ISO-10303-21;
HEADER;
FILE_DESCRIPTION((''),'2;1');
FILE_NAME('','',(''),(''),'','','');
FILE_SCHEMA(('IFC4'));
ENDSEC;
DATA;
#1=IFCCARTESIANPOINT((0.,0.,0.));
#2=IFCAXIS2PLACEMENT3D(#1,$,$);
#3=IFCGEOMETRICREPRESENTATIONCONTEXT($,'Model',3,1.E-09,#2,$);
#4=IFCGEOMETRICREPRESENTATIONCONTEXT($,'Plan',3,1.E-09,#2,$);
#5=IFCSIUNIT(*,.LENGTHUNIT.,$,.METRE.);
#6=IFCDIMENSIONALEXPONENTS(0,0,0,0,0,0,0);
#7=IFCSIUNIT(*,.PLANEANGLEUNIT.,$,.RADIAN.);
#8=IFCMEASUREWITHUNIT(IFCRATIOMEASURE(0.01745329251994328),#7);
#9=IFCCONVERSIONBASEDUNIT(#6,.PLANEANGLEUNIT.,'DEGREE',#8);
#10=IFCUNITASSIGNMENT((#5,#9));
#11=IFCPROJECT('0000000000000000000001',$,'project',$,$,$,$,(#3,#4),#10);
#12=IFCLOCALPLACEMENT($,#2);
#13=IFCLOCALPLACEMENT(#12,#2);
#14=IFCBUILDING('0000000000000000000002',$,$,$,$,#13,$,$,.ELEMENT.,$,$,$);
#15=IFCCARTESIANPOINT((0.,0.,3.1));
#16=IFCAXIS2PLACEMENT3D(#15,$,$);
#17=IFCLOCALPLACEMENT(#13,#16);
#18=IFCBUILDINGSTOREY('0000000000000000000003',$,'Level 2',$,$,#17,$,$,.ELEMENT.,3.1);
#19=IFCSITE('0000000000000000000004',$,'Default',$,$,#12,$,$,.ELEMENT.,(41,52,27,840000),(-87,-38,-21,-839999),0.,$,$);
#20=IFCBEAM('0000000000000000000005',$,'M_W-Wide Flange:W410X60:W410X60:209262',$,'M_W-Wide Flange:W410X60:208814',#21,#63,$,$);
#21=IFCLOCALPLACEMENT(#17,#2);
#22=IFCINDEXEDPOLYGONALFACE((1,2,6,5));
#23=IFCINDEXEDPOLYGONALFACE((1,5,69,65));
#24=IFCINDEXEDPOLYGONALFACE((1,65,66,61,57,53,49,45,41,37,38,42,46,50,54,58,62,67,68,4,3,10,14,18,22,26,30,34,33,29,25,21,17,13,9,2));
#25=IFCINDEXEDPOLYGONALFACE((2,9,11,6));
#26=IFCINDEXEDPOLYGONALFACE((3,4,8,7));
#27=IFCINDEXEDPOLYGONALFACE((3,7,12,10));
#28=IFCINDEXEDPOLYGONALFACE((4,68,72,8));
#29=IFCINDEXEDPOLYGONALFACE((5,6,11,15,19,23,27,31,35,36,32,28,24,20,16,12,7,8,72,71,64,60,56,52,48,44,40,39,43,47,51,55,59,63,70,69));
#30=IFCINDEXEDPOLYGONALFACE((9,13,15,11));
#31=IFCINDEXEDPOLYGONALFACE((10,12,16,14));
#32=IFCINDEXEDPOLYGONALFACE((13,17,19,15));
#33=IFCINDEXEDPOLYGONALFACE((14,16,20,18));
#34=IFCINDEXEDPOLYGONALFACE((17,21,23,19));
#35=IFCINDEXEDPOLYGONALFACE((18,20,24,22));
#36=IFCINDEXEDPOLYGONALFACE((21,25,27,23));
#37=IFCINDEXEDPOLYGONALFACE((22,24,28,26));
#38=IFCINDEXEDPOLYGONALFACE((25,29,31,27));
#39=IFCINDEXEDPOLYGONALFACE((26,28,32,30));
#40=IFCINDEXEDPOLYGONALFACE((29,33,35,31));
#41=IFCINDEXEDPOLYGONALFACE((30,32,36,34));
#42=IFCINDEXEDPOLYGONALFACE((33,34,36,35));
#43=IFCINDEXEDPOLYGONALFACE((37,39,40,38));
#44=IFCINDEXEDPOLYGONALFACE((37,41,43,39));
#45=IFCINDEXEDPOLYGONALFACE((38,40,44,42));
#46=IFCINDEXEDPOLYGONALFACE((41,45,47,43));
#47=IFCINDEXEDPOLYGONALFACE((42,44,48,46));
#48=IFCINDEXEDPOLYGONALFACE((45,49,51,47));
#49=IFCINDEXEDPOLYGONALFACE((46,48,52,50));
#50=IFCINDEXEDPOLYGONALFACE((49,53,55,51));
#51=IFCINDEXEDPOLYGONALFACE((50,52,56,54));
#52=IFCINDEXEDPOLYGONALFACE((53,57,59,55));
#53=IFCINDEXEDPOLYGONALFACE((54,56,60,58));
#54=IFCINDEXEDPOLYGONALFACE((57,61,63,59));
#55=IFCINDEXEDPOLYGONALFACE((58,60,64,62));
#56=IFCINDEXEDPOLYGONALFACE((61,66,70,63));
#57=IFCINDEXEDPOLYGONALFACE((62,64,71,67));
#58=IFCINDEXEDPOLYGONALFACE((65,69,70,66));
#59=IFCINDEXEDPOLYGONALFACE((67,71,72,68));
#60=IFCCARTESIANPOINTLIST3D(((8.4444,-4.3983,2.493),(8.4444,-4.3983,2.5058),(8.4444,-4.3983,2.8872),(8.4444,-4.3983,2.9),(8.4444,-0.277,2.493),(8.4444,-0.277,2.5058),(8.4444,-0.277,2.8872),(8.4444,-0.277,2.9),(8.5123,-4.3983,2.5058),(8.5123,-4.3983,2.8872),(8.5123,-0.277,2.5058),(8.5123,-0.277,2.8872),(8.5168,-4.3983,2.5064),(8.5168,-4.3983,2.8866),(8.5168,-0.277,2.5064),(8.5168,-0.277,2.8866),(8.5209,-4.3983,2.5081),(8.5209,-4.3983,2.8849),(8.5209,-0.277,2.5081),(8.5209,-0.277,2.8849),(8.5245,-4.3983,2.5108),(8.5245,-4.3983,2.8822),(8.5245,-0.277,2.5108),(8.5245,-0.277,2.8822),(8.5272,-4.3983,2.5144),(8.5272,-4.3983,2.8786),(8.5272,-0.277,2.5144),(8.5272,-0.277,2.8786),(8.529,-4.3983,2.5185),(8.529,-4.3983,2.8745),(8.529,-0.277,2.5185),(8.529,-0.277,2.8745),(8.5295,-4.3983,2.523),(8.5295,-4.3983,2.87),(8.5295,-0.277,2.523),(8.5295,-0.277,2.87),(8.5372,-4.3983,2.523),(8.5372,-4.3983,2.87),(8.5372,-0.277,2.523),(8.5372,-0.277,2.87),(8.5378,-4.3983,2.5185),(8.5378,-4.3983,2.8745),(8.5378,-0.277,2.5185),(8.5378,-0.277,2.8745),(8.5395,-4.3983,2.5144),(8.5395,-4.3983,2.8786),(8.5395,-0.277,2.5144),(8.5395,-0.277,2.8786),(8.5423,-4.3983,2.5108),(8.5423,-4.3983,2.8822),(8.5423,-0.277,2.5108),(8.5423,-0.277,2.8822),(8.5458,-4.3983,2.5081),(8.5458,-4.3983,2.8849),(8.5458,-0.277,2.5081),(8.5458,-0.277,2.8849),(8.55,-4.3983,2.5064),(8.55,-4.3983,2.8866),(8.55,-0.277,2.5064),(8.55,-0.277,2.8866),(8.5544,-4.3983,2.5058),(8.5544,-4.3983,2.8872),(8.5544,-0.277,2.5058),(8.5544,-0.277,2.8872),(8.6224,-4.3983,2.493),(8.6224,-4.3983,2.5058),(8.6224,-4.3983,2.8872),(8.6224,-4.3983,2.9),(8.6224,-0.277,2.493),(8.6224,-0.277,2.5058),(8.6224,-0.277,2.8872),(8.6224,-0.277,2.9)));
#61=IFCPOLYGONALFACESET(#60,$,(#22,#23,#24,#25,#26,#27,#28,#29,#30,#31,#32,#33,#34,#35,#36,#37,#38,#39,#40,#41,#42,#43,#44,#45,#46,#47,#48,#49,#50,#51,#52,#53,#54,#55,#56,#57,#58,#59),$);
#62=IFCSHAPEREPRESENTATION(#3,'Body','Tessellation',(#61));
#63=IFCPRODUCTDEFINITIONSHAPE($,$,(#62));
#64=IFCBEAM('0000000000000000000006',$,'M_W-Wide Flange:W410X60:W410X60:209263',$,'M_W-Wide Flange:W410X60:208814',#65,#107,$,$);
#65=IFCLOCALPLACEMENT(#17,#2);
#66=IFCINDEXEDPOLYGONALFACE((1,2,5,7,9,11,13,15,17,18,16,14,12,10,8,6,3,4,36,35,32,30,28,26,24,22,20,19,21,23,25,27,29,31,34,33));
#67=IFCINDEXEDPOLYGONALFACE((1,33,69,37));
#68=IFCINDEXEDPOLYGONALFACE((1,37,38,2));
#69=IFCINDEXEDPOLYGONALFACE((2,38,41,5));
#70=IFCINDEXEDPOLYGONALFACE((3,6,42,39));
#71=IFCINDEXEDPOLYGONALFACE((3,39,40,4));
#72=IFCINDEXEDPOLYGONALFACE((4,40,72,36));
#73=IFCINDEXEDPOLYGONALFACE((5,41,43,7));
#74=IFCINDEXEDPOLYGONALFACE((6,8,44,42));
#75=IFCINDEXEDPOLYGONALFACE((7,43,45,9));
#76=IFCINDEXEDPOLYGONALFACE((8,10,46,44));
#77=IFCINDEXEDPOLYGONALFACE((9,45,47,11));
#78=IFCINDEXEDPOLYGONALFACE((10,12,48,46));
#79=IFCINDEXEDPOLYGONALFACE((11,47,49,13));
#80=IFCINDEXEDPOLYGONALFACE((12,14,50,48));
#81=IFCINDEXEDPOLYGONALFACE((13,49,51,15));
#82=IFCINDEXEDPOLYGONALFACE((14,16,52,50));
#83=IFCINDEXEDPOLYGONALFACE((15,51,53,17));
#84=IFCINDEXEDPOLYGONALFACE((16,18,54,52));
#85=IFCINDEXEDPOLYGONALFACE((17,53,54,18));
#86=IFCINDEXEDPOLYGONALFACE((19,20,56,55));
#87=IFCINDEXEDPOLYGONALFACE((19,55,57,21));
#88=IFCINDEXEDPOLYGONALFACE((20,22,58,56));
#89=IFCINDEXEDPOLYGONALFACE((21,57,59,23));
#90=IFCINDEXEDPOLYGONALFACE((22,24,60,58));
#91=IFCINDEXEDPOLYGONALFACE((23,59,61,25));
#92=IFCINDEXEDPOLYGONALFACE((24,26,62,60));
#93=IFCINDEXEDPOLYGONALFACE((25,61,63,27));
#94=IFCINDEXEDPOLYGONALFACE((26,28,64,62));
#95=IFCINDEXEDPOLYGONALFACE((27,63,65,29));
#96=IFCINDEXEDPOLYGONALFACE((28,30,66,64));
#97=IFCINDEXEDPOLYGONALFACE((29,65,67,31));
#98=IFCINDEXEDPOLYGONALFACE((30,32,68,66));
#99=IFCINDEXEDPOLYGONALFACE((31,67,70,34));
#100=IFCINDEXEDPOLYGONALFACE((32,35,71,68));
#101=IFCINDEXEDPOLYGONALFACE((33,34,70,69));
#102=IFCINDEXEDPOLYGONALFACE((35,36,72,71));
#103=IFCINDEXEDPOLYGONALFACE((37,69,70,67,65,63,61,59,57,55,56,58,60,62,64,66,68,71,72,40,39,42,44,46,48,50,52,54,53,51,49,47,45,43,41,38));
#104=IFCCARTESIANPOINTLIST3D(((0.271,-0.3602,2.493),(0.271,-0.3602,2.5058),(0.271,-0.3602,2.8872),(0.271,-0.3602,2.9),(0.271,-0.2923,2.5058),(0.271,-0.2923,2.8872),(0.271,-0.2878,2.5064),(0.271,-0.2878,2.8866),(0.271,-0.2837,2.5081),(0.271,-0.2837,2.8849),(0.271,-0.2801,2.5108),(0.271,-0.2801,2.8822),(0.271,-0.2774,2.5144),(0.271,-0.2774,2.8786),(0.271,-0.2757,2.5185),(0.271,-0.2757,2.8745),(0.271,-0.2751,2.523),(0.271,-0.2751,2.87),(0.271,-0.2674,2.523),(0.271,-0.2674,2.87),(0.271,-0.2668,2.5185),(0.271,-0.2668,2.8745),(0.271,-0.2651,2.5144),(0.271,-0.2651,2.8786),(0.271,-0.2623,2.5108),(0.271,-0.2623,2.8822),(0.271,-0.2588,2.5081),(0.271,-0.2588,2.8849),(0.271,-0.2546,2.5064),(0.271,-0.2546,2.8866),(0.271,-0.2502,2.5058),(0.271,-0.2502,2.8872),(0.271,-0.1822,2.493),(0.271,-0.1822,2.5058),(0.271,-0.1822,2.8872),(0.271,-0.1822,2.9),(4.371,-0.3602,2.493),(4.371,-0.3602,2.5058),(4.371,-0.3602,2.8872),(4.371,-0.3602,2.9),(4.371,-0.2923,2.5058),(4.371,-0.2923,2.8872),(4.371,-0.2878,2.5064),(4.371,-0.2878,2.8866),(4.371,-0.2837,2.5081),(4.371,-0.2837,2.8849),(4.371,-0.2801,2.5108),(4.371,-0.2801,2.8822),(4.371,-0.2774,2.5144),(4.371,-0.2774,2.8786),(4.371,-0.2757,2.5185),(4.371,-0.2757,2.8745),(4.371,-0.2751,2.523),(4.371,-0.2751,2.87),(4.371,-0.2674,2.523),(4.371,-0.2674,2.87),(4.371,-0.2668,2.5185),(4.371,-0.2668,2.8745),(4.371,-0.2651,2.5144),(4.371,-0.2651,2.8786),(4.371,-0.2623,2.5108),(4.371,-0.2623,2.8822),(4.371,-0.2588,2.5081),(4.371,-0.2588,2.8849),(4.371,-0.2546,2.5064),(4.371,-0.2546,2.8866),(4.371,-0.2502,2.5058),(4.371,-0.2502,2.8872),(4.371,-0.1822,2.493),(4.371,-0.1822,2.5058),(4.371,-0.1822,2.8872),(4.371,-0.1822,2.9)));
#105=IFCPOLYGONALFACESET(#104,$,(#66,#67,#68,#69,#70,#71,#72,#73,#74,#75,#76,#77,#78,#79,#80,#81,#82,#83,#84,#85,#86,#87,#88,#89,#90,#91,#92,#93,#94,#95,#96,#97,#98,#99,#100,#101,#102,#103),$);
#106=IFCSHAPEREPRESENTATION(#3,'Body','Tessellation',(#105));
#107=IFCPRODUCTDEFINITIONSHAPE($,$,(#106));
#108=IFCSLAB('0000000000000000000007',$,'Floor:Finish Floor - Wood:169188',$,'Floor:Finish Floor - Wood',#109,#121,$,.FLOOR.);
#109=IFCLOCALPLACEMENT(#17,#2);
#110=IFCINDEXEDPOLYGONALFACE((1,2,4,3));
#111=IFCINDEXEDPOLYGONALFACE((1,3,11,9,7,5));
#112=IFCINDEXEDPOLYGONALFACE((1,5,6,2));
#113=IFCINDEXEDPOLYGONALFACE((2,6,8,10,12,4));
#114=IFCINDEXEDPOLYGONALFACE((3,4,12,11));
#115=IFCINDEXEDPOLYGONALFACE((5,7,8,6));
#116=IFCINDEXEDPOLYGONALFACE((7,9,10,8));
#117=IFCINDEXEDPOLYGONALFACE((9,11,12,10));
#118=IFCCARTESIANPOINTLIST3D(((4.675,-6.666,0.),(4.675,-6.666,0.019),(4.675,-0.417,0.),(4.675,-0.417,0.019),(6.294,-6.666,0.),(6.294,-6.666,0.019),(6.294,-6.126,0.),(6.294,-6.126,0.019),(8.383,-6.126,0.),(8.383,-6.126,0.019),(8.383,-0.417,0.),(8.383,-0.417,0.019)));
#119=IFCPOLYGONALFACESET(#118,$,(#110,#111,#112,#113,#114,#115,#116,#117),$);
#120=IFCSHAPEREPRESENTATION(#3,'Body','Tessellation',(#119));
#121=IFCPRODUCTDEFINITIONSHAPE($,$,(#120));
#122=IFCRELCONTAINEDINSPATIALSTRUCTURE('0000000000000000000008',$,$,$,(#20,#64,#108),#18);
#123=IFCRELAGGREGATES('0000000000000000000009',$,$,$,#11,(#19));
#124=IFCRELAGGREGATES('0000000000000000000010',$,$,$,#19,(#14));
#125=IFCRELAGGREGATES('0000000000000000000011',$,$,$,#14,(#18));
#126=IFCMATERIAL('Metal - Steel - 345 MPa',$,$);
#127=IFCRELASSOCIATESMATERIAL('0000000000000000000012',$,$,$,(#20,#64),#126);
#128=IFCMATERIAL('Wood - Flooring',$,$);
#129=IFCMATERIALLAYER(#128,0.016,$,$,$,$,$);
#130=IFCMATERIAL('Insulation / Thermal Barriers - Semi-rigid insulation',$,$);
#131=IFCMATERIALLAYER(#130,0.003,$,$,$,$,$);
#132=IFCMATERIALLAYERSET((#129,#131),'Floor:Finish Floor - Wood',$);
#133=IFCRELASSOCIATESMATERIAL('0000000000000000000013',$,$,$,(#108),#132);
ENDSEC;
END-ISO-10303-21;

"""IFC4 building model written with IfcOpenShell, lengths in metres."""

from ifc_helpers import new_model, entity, si_unit, converted_unit, frame, frame_2d, origin, place, context, project, spatial, polyline, circle_curve, parameter, trimmed, segment, composite_curve, outline, extrude, material, layer, layer_set, layer_usage, element, save


model = new_model("IFC4")

# Units and contexts
model_context = context("Model", 3, precision=1e-09, world=origin())
plan_context = context("Plan", 3, precision=1e-09, world=origin())
ifc_project = project(units=[si_unit("LENGTHUNIT", "METRE"), converted_unit("PLANEANGLEUNIT", "DEGREE", entity("IfcRatioMeasure", 0.01745329251994328), si_unit("PLANEANGLEUNIT", "RADIAN"), dimensions=[0, 0, 0, 0, 0, 0, 0])], contexts=[model_context, plan_context])

# Site, building, storey
site_placement = place(None, origin())
site = spatial("IfcSite", under=ifc_project, at=site_placement, Name="Default", CompositionType="ELEMENT", RefLatitude=(41, 52, 27, 840000), RefLongitude=(-87, -38, -21, -839999), RefElevation=0.0)
building_placement = place(site_placement, origin())
building = spatial("IfcBuilding", under=site, at=building_placement, CompositionType="ELEMENT")
storey_placement = place(building_placement, frame((0.0, 0.0, 3.1)))
storey = spatial("IfcBuildingStorey", under=building, at=storey_placement, Name="Level 2", CompositionType="ELEMENT", Elevation=3.1)

# Beams
ifc_material_1 = material(Name="Metal - Steel - 345 MPa")
beam_1_placement = place(storey_placement, frame((8.5334, -4.3983, 2.9)))
element("IfcBeam", 1, at=beam_1_placement, inside=storey, material=ifc_material_1, Name="M_W-Wide Flange:W410X60:W410X60:209262", ObjectType="M_W-Wide Flange:W410X60:208814", context=model_context, shape_type="SweptSolid", body=[
    extrude(outline(composite_curve([segment(polyline([(-0.089, -0.1907), (-0.089, -0.2035)]), True, "CONTINUOUS"), segment(polyline([(-0.089, -0.2035), (0.089, -0.2035)]), True, "CONTINUOUS"), segment(polyline([(0.089, -0.2035), (0.089, -0.1907)]), True, "CONTINUOUS"), segment(polyline([(0.089, -0.1907), (0.021, -0.1907)]), True, "CONTINUOUS"), segment(trimmed(circle_curve(frame_2d((0.021, -0.1735), x_axis=(0.0, -1.0)), 0.0172), [parameter(270.0)], [parameter(360.0)], True, "PARAMETER"), False, "CONTINUOUS"), segment(polyline([(0.0038, -0.1735), (0.0038, 0.1735)]), True, "CONTINUOUS"), segment(trimmed(circle_curve(frame_2d((0.021, 0.1735), x_axis=(-1.0, 0.0)), 0.0172), [parameter(270.0)], [parameter(360.0)], True, "PARAMETER"), False, "CONTINUOUS"), segment(polyline([(0.021, 0.1907), (0.089, 0.1907)]), True, "CONTINUOUS"), segment(polyline([(0.089, 0.1907), (0.089, 0.2035)]), True, "CONTINUOUS"), segment(polyline([(0.089, 0.2035), (-0.089, 0.2035)]), True, "CONTINUOUS"), segment(polyline([(-0.089, 0.2035), (-0.089, 0.1907)]), True, "CONTINUOUS"), segment(polyline([(-0.089, 0.1907), (-0.0211, 0.1907)]), True, "CONTINUOUS"), segment(trimmed(circle_curve(frame_2d((-0.0211, 0.1735), x_axis=(0.0, 1.0)), 0.0172), [parameter(270.0)], [parameter(0.0)], True, "PARAMETER"), False, "CONTINUOUS"), segment(polyline([(-0.0039, 0.1735), (-0.0039, -0.1735)]), True, "CONTINUOUS"), segment(trimmed(circle_curve(frame_2d((-0.0211, -0.1735), x_axis=(1.0, 0.0)), 0.0172), [parameter(270.0)], [parameter(0.0)], True, "PARAMETER"), False, "CONTINUOUS"), segment(polyline([(-0.0211, -0.1907), (-0.089, -0.1907)]), True, "CONTINUOUS")], self_intersect=False)), frame((0.0, 0.0, -0.2035), z_axis=(0.0, -1.0, 0.0), x_axis=(1.0, 0.0, 0.0)), (0.0, 0.0, -1.0), 4.1213),
])
beam_2_placement = place(storey_placement, frame((4.371, -0.2712, 2.9), z_axis=(0.0, 0.0, 1.0), x_axis=(0.0, 1.0, 0.0)))
element("IfcBeam", 2, at=beam_2_placement, inside=storey, material=ifc_material_1, Name="M_W-Wide Flange:W410X60:W410X60:209263", ObjectType="M_W-Wide Flange:W410X60:208814", context=model_context, shape_type="SweptSolid", body=[
    extrude(outline(composite_curve([segment(polyline([(0.1907, -0.089), (0.2035, -0.089)]), True, "CONTINUOUS"), segment(polyline([(0.2035, -0.089), (0.2035, 0.089)]), True, "CONTINUOUS"), segment(polyline([(0.2035, 0.089), (0.1907, 0.089)]), True, "CONTINUOUS"), segment(polyline([(0.1907, 0.089), (0.1907, 0.0211)]), True, "CONTINUOUS"), segment(trimmed(circle_curve(frame_2d((0.1735, 0.0211), x_axis=(1.0, 0.0)), 0.0172), [parameter(270.0)], [parameter(360.0)], True, "PARAMETER"), False, "CONTINUOUS"), segment(polyline([(0.1735, 0.0039), (-0.1735, 0.0039)]), True, "CONTINUOUS"), segment(trimmed(circle_curve(frame_2d((-0.1735, 0.0211), x_axis=(0.0, -1.0)), 0.0172), [parameter(270.0)], [parameter(360.0)], True, "PARAMETER"), False, "CONTINUOUS"), segment(polyline([(-0.1907, 0.0211), (-0.1907, 0.089)]), True, "CONTINUOUS"), segment(polyline([(-0.1907, 0.089), (-0.2035, 0.089)]), True, "CONTINUOUS"), segment(polyline([(-0.2035, 0.089), (-0.2035, -0.089)]), True, "CONTINUOUS"), segment(polyline([(-0.2035, -0.089), (-0.1907, -0.089)]), True, "CONTINUOUS"), segment(polyline([(-0.1907, -0.089), (-0.1907, -0.0211)]), True, "CONTINUOUS"), segment(trimmed(circle_curve(frame_2d((-0.1735, -0.0211), x_axis=(-1.0, 0.0)), 0.0172), [parameter(270.0)], [parameter(0.0)], True, "PARAMETER"), False, "CONTINUOUS"), segment(polyline([(-0.1735, -0.0039), (0.1735, -0.0039)]), True, "CONTINUOUS"), segment(trimmed(circle_curve(frame_2d((0.1735, -0.0211), x_axis=(0.0, 1.0)), 0.0172), [parameter(270.0)], [parameter(0.0)], True, "PARAMETER"), False, "CONTINUOUS"), segment(polyline([(0.1907, -0.0211), (0.1907, -0.089)]), True, "CONTINUOUS")], self_intersect=False)), frame((0.0, 4.1, -0.2035), z_axis=(0.0, -1.0, 0.0), x_axis=(0.0, 0.0, -1.0)), (0.0, 0.0, 1.0), 4.1),
])

# Slab
ifc_material_2 = material(Name="Wood - Flooring")
ifc_layer_1 = layer(ifc_material_2, 0.016)
ifc_material_3 = material(Name="Insulation / Thermal Barriers - Semi-rigid insulation")
ifc_layer_2 = layer(ifc_material_3, 0.003)
ifc_layer_set_1 = layer_set([ifc_layer_1, ifc_layer_2], Name="Floor:Finish Floor - Wood")
ifc_layer_usage_1 = layer_usage(ifc_layer_set_1, "AXIS3", "POSITIVE", 0.0)
slab_placement = place(storey_placement, frame((4.675, -6.666, 0.0)))
element("IfcSlab", 3, at=slab_placement, inside=storey, material=ifc_layer_usage_1, Name="Floor:Finish Floor - Wood:169188", ObjectType="Floor:Finish Floor - Wood", PredefinedType="FLOOR", context=model_context, shape_type="SweptSolid", body=[
    extrude(outline(polyline([(-1.854, 3.1245), (-1.854, -2.5845), (0.235, -2.5845), (0.235, -3.1245), (1.854, -3.1245), (1.854, 3.1245), (-1.854, 3.1245)])), frame((1.854, 3.1245, 0.019), z_axis=(0.0, 0.0, -1.0), x_axis=(-1.0, 0.0, 0.0)), (0.0, 0.0, 1.0), 0.019),
])

save(model, "model.ifc")
